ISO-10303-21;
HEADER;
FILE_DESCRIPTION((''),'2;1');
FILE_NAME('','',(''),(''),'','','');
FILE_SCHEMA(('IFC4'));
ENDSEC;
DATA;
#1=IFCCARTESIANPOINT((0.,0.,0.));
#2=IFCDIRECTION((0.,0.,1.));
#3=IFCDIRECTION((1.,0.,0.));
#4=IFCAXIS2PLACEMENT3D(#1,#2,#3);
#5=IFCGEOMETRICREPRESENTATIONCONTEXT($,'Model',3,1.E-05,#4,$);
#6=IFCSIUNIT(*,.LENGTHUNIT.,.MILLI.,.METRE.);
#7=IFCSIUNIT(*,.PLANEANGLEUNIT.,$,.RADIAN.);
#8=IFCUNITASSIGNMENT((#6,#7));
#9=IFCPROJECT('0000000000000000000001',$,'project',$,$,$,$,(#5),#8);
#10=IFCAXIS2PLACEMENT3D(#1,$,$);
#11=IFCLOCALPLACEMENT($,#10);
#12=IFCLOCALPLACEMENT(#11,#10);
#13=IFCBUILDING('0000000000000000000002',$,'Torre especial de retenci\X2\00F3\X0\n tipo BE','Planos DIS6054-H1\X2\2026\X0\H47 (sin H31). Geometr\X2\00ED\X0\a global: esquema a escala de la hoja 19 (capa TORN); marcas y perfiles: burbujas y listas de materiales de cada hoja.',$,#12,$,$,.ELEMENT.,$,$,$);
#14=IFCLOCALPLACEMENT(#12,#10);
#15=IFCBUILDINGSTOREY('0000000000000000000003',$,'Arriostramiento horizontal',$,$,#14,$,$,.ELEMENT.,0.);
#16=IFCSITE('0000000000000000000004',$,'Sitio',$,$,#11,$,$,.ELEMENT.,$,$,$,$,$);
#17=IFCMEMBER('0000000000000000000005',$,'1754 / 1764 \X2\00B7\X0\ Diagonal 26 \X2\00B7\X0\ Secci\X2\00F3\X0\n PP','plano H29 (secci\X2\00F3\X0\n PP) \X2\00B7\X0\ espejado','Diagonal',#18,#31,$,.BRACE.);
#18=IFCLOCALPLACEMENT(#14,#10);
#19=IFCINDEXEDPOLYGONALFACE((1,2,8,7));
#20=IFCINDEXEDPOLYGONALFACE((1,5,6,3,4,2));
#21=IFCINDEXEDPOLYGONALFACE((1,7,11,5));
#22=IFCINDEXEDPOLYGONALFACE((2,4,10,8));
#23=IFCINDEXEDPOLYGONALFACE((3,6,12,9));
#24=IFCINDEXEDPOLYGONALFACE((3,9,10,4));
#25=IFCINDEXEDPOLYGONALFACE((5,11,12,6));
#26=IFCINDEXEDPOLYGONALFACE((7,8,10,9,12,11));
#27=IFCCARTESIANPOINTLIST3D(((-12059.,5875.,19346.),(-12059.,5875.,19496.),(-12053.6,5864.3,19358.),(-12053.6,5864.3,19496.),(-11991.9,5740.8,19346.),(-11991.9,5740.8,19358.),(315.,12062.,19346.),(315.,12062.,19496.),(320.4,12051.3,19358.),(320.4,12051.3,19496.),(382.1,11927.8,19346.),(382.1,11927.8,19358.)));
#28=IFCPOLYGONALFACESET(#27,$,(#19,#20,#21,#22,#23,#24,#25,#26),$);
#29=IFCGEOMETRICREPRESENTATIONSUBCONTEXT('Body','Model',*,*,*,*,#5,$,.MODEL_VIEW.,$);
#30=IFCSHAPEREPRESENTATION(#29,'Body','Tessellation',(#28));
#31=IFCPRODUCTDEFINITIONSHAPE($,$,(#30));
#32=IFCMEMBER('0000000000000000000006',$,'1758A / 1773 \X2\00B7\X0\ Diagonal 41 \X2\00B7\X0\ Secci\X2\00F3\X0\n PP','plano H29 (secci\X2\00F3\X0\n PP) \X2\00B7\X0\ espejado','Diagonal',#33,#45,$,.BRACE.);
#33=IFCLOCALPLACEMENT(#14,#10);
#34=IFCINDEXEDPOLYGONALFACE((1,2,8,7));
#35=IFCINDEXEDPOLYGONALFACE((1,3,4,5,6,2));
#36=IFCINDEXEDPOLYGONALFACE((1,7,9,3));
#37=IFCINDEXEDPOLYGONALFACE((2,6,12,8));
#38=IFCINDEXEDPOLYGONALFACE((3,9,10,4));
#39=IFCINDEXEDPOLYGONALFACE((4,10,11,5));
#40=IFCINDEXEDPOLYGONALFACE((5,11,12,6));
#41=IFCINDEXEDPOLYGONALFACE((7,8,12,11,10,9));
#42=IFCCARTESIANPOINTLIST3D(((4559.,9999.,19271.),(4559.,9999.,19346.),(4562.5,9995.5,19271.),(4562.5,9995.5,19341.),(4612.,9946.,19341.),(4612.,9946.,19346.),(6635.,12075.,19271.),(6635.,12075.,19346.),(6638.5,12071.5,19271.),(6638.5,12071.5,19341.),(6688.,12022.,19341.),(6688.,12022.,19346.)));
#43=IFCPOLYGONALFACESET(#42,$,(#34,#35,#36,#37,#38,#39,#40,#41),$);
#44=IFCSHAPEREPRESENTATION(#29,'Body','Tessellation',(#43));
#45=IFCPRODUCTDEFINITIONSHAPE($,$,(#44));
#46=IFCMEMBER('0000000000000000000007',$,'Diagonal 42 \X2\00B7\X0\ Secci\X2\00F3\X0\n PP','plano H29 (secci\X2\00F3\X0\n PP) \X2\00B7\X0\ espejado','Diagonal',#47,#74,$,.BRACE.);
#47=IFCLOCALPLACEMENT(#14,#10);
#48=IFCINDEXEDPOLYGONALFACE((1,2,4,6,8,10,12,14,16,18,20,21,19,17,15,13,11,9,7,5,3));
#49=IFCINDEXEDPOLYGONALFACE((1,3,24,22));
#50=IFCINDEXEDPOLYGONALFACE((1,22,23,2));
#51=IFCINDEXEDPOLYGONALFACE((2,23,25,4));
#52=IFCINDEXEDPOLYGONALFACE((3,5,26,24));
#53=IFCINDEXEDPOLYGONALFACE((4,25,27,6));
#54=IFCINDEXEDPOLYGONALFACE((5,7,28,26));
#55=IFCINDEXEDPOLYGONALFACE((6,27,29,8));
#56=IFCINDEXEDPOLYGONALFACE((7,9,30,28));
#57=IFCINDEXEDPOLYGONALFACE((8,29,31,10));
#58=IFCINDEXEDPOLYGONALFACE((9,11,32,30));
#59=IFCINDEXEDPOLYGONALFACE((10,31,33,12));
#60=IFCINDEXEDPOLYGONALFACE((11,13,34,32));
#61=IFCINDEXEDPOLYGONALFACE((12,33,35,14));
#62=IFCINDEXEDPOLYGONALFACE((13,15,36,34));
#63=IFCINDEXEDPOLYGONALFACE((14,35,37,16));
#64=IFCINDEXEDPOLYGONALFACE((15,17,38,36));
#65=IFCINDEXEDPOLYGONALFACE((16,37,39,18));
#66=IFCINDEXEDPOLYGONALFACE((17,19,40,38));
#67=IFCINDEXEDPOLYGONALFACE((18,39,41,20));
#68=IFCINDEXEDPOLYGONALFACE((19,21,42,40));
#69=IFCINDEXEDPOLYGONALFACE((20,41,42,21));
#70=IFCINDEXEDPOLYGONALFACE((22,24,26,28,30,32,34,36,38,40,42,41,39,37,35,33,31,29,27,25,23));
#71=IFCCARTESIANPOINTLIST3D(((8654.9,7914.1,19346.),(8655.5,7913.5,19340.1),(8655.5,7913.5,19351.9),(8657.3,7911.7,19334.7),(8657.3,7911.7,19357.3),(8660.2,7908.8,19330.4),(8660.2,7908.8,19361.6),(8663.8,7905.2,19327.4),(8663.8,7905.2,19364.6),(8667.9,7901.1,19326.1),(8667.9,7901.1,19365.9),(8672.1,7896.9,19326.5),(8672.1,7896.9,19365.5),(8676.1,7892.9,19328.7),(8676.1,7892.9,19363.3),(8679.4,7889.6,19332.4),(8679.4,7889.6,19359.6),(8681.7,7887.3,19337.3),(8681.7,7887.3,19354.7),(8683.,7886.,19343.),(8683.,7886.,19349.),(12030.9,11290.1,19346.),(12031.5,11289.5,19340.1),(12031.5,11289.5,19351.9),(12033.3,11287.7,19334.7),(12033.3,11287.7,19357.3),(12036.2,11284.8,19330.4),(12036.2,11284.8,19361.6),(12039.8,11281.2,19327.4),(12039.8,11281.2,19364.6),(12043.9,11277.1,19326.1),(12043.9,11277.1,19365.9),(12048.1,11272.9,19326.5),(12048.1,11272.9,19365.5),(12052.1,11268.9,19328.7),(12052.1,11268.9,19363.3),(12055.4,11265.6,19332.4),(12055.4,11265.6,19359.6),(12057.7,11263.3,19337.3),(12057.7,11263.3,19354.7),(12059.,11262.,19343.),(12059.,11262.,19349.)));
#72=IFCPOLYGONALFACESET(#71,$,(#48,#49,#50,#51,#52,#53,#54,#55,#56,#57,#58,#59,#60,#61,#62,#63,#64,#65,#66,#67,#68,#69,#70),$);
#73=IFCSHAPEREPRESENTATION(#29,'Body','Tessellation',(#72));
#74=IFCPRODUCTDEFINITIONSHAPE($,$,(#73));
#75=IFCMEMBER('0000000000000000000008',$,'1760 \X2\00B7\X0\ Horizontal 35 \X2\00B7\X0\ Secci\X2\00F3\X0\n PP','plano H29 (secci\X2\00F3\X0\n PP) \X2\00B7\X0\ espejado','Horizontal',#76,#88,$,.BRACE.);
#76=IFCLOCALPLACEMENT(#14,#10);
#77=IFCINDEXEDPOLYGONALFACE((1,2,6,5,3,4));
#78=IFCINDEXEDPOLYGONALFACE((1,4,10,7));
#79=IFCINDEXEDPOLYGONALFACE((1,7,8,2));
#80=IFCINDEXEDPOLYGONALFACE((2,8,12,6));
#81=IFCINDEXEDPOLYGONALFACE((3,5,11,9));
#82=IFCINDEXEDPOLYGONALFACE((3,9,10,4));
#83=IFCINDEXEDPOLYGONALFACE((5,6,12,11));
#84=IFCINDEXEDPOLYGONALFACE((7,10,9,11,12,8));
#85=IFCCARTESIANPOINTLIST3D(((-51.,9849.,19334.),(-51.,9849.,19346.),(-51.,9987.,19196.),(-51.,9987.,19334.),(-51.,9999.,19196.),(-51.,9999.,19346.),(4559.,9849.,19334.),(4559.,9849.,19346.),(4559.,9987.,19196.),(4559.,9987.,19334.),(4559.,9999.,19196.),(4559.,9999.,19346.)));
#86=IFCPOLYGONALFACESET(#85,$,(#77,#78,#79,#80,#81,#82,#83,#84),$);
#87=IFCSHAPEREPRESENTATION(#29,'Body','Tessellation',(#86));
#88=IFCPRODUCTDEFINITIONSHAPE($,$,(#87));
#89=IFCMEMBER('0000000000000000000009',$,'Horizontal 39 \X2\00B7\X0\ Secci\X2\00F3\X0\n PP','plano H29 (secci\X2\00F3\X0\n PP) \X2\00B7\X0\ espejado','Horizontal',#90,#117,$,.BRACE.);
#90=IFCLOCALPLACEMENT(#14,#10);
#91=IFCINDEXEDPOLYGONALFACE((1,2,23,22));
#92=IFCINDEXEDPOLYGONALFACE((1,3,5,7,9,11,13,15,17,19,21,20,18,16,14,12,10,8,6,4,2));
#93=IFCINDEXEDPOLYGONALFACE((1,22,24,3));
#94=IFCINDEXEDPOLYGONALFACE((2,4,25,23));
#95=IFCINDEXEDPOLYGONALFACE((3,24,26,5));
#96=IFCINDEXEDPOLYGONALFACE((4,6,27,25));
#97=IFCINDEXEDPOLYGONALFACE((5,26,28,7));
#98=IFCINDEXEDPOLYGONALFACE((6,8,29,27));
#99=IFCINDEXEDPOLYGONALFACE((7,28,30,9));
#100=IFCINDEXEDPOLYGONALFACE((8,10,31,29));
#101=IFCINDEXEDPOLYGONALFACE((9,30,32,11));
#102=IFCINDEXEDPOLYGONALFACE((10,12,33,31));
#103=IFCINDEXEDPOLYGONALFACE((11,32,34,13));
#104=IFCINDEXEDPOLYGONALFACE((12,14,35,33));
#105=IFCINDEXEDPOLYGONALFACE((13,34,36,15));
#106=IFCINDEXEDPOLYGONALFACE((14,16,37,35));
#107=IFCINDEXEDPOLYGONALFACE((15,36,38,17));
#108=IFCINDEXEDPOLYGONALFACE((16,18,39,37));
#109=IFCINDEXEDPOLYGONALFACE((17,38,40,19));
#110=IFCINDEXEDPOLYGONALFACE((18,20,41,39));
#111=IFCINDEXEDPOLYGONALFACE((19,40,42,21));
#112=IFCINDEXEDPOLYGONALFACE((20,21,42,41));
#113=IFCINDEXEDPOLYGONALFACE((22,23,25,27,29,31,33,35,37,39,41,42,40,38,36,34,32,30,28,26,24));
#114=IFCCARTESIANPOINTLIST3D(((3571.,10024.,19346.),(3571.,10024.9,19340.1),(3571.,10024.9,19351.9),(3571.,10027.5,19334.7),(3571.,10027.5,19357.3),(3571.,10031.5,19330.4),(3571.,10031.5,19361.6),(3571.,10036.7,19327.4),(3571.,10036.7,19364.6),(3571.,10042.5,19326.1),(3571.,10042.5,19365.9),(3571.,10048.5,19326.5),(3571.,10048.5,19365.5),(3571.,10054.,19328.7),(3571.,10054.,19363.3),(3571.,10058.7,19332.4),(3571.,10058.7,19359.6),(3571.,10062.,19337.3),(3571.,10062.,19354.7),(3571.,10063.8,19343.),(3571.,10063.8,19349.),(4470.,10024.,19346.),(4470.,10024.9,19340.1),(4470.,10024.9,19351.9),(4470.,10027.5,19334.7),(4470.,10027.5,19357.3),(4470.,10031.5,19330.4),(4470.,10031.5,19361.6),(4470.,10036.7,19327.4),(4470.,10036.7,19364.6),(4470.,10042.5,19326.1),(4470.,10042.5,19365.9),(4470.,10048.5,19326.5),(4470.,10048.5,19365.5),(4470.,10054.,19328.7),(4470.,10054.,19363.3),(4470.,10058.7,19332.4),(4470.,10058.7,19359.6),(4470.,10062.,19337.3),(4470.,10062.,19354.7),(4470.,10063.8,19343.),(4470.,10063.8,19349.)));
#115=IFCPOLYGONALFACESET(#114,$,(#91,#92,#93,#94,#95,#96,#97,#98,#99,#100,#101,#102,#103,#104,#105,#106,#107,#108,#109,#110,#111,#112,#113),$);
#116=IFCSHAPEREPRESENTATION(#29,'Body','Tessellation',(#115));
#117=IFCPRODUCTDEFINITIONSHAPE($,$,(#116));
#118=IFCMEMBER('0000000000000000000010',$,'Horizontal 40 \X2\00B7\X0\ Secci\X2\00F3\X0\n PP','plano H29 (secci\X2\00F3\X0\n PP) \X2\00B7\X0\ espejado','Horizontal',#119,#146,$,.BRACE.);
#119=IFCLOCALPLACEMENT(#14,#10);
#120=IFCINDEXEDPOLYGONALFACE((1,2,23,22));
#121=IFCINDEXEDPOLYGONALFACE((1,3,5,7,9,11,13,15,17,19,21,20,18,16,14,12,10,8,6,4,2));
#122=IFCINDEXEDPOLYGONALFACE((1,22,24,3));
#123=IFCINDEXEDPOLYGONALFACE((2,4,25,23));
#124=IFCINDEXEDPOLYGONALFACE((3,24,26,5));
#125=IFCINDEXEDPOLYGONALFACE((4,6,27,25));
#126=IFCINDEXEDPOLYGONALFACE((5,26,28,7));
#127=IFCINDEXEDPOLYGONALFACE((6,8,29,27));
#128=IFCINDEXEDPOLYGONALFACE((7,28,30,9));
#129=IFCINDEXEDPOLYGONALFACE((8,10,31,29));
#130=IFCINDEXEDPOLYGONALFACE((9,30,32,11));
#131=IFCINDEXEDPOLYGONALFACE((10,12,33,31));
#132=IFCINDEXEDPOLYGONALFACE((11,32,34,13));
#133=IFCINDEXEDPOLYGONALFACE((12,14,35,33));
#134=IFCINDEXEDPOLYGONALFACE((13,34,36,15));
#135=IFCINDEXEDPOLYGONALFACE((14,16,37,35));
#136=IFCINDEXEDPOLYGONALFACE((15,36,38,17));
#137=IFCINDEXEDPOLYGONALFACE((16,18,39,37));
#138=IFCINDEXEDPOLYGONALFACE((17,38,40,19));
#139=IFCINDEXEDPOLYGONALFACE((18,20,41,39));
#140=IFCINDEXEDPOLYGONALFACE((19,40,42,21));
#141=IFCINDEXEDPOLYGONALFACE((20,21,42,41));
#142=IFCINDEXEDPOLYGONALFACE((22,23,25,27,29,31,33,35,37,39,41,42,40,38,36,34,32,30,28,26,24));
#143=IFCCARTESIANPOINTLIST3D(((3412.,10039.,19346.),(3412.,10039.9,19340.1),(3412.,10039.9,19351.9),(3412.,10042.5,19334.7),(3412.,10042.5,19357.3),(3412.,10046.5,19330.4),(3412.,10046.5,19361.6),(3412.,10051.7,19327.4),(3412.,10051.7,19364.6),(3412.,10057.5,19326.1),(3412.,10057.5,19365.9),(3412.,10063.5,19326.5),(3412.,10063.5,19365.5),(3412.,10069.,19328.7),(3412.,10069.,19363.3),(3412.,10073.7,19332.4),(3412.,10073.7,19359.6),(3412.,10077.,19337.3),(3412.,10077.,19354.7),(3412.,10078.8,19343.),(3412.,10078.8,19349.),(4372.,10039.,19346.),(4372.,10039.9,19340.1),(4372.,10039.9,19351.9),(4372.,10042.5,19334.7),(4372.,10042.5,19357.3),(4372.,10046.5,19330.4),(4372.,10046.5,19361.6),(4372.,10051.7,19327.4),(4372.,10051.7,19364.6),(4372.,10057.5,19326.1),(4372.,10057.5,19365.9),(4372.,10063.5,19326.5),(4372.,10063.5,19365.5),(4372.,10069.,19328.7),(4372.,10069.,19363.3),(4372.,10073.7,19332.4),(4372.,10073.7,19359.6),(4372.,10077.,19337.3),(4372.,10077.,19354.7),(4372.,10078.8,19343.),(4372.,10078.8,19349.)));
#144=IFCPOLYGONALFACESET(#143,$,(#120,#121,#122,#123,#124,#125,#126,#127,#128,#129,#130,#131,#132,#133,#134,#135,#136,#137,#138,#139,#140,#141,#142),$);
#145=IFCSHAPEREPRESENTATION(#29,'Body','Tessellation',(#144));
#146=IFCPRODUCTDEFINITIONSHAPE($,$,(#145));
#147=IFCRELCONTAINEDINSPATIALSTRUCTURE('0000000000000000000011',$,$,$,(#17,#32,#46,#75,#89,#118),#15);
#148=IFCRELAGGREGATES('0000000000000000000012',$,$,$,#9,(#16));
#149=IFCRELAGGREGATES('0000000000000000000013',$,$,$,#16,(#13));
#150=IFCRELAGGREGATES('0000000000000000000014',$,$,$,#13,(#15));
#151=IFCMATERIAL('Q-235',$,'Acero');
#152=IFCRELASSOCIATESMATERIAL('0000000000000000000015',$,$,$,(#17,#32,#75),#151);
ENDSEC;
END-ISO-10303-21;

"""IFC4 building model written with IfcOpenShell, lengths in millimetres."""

from ifc_helpers import new_model, si_unit, frame, frame_2d, origin, origin_with_axes, place, context, subcontext, project, spatial, circle, l_section, extrude, material, element, save


model = new_model("IFC4")

# Units and contexts
model_context = context("Model", 3, precision=1e-05, world=origin_with_axes())
body_context = subcontext(model_context, "Body", "Model", "MODEL_VIEW")
ifc_project = project(units=[si_unit("LENGTHUNIT", "METRE", prefix="MILLI"), si_unit("PLANEANGLEUNIT", "RADIAN")], contexts=[model_context])

# Site, building, storey
site_placement = place(None, origin())
site = spatial("IfcSite", under=ifc_project, at=site_placement, Name="Sitio", CompositionType="ELEMENT")
building_placement = place(site_placement, origin())
building = spatial("IfcBuilding", under=site, at=building_placement, Name="Torre especial de retención tipo BE", Description="Planos DIS6054-H1…H47 (sin H31). Geometría global: esquema a escala de la hoja 19 (capa TORN); marcas y perfiles: burbujas y listas de materiales de cada hoja.", CompositionType="ELEMENT")
storey_placement = place(building_placement, origin())
storey = spatial("IfcBuildingStorey", under=building, at=storey_placement, Name="Arriostramiento horizontal", CompositionType="ELEMENT", Elevation=0.0)

# Members
ifc_material = material(Name="Q-235", Category="Acero")
member_1_placement = place(storey_placement, frame((315.0, 12062.0, 19346.0), z_axis=(-0.894427, -0.447214, 0.0), x_axis=(0.447214, -0.894427, 0.0)))
element("IfcMember", 1, at=member_1_placement, inside=storey, material=ifc_material, Name="1754 / 1764 · Diagonal 26 · Sección PP", Description="plano H29 (sección PP) · espejado", ObjectType="Diagonal", PredefinedType="BRACE", context=body_context, shape_type="SweptSolid", body=[
    extrude(l_section(Depth=150.0, Width=150.0, Thickness=12.0, at=frame_2d((75.0, 75.0))), None, (0.0, 0.0, 1.0), 13834.6),
])
member_2_placement = place(storey_placement, frame((4559.0, 9999.0, 19346.0), z_axis=(0.707107, 0.707107, 0.0), x_axis=(0.707107, -0.707107, 0.0)))
element("IfcMember", 2, at=member_2_placement, inside=storey, material=ifc_material, Name="1758A / 1773 · Diagonal 41 · Sección PP", Description="plano H29 (sección PP) · espejado", ObjectType="Diagonal", PredefinedType="BRACE", context=body_context, shape_type="SweptSolid", body=[
    extrude(l_section(Depth=75.0, Width=75.0, Thickness=5.0, at=frame_2d((37.5, 37.5))), None, (0.0, 0.0, 1.0), 2935.9),
])
member_3_placement = place(storey_placement, frame((8669.0, 7900.0, 19346.0), z_axis=(0.707107, 0.707107, 0.0), x_axis=(-0.707107, 0.707107, 0.0)))
element("IfcMember", 3, at=member_3_placement, inside=storey, Name="Diagonal 42 · Sección PP", Description="plano H29 (sección PP) · espejado", ObjectType="Diagonal", PredefinedType="BRACE", context=body_context, shape_type="SweptSolid", body=[
    extrude(circle(Radius=20.0), None, (0.0, 0.0, 1.0), 4774.4),
])
member_4_placement = place(storey_placement, frame((-51.0, 9999.0, 19346.0), z_axis=(1.0, 0.0, 0.0), x_axis=(0.0, -1.0, 0.0)))
element("IfcMember", 4, at=member_4_placement, inside=storey, material=ifc_material, Name="1760 · Horizontal 35 · Sección PP", Description="plano H29 (sección PP) · espejado", ObjectType="Horizontal", PredefinedType="BRACE", context=body_context, shape_type="SweptSolid", body=[
    extrude(l_section(Depth=150.0, Width=150.0, Thickness=12.0, at=frame_2d((75.0, 75.0))), None, (0.0, 0.0, 1.0), 4610.0),
])
member_5_placement = place(storey_placement, frame((4470.0, 10044.0, 19346.0), z_axis=(-1.0, 0.0, 0.0), x_axis=(0.0, -1.0, 0.0)))
element("IfcMember", 5, at=member_5_placement, inside=storey, Name="Horizontal 39 · Sección PP", Description="plano H29 (sección PP) · espejado", ObjectType="Horizontal", PredefinedType="BRACE", context=body_context, shape_type="SweptSolid", body=[
    extrude(circle(Radius=20.0), None, (0.0, 0.0, 1.0), 899.0),
])
member_6_placement = place(storey_placement, frame((4372.0, 10059.0, 19346.0), z_axis=(-1.0, 0.0, 0.0), x_axis=(0.0, -1.0, 0.0)))
element("IfcMember", 6, at=member_6_placement, inside=storey, Name="Horizontal 40 · Sección PP", Description="plano H29 (sección PP) · espejado", ObjectType="Horizontal", PredefinedType="BRACE", context=body_context, shape_type="SweptSolid", body=[
    extrude(circle(Radius=20.0), None, (0.0, 0.0, 1.0), 960.0),
])

save(model, "model.ifc")
